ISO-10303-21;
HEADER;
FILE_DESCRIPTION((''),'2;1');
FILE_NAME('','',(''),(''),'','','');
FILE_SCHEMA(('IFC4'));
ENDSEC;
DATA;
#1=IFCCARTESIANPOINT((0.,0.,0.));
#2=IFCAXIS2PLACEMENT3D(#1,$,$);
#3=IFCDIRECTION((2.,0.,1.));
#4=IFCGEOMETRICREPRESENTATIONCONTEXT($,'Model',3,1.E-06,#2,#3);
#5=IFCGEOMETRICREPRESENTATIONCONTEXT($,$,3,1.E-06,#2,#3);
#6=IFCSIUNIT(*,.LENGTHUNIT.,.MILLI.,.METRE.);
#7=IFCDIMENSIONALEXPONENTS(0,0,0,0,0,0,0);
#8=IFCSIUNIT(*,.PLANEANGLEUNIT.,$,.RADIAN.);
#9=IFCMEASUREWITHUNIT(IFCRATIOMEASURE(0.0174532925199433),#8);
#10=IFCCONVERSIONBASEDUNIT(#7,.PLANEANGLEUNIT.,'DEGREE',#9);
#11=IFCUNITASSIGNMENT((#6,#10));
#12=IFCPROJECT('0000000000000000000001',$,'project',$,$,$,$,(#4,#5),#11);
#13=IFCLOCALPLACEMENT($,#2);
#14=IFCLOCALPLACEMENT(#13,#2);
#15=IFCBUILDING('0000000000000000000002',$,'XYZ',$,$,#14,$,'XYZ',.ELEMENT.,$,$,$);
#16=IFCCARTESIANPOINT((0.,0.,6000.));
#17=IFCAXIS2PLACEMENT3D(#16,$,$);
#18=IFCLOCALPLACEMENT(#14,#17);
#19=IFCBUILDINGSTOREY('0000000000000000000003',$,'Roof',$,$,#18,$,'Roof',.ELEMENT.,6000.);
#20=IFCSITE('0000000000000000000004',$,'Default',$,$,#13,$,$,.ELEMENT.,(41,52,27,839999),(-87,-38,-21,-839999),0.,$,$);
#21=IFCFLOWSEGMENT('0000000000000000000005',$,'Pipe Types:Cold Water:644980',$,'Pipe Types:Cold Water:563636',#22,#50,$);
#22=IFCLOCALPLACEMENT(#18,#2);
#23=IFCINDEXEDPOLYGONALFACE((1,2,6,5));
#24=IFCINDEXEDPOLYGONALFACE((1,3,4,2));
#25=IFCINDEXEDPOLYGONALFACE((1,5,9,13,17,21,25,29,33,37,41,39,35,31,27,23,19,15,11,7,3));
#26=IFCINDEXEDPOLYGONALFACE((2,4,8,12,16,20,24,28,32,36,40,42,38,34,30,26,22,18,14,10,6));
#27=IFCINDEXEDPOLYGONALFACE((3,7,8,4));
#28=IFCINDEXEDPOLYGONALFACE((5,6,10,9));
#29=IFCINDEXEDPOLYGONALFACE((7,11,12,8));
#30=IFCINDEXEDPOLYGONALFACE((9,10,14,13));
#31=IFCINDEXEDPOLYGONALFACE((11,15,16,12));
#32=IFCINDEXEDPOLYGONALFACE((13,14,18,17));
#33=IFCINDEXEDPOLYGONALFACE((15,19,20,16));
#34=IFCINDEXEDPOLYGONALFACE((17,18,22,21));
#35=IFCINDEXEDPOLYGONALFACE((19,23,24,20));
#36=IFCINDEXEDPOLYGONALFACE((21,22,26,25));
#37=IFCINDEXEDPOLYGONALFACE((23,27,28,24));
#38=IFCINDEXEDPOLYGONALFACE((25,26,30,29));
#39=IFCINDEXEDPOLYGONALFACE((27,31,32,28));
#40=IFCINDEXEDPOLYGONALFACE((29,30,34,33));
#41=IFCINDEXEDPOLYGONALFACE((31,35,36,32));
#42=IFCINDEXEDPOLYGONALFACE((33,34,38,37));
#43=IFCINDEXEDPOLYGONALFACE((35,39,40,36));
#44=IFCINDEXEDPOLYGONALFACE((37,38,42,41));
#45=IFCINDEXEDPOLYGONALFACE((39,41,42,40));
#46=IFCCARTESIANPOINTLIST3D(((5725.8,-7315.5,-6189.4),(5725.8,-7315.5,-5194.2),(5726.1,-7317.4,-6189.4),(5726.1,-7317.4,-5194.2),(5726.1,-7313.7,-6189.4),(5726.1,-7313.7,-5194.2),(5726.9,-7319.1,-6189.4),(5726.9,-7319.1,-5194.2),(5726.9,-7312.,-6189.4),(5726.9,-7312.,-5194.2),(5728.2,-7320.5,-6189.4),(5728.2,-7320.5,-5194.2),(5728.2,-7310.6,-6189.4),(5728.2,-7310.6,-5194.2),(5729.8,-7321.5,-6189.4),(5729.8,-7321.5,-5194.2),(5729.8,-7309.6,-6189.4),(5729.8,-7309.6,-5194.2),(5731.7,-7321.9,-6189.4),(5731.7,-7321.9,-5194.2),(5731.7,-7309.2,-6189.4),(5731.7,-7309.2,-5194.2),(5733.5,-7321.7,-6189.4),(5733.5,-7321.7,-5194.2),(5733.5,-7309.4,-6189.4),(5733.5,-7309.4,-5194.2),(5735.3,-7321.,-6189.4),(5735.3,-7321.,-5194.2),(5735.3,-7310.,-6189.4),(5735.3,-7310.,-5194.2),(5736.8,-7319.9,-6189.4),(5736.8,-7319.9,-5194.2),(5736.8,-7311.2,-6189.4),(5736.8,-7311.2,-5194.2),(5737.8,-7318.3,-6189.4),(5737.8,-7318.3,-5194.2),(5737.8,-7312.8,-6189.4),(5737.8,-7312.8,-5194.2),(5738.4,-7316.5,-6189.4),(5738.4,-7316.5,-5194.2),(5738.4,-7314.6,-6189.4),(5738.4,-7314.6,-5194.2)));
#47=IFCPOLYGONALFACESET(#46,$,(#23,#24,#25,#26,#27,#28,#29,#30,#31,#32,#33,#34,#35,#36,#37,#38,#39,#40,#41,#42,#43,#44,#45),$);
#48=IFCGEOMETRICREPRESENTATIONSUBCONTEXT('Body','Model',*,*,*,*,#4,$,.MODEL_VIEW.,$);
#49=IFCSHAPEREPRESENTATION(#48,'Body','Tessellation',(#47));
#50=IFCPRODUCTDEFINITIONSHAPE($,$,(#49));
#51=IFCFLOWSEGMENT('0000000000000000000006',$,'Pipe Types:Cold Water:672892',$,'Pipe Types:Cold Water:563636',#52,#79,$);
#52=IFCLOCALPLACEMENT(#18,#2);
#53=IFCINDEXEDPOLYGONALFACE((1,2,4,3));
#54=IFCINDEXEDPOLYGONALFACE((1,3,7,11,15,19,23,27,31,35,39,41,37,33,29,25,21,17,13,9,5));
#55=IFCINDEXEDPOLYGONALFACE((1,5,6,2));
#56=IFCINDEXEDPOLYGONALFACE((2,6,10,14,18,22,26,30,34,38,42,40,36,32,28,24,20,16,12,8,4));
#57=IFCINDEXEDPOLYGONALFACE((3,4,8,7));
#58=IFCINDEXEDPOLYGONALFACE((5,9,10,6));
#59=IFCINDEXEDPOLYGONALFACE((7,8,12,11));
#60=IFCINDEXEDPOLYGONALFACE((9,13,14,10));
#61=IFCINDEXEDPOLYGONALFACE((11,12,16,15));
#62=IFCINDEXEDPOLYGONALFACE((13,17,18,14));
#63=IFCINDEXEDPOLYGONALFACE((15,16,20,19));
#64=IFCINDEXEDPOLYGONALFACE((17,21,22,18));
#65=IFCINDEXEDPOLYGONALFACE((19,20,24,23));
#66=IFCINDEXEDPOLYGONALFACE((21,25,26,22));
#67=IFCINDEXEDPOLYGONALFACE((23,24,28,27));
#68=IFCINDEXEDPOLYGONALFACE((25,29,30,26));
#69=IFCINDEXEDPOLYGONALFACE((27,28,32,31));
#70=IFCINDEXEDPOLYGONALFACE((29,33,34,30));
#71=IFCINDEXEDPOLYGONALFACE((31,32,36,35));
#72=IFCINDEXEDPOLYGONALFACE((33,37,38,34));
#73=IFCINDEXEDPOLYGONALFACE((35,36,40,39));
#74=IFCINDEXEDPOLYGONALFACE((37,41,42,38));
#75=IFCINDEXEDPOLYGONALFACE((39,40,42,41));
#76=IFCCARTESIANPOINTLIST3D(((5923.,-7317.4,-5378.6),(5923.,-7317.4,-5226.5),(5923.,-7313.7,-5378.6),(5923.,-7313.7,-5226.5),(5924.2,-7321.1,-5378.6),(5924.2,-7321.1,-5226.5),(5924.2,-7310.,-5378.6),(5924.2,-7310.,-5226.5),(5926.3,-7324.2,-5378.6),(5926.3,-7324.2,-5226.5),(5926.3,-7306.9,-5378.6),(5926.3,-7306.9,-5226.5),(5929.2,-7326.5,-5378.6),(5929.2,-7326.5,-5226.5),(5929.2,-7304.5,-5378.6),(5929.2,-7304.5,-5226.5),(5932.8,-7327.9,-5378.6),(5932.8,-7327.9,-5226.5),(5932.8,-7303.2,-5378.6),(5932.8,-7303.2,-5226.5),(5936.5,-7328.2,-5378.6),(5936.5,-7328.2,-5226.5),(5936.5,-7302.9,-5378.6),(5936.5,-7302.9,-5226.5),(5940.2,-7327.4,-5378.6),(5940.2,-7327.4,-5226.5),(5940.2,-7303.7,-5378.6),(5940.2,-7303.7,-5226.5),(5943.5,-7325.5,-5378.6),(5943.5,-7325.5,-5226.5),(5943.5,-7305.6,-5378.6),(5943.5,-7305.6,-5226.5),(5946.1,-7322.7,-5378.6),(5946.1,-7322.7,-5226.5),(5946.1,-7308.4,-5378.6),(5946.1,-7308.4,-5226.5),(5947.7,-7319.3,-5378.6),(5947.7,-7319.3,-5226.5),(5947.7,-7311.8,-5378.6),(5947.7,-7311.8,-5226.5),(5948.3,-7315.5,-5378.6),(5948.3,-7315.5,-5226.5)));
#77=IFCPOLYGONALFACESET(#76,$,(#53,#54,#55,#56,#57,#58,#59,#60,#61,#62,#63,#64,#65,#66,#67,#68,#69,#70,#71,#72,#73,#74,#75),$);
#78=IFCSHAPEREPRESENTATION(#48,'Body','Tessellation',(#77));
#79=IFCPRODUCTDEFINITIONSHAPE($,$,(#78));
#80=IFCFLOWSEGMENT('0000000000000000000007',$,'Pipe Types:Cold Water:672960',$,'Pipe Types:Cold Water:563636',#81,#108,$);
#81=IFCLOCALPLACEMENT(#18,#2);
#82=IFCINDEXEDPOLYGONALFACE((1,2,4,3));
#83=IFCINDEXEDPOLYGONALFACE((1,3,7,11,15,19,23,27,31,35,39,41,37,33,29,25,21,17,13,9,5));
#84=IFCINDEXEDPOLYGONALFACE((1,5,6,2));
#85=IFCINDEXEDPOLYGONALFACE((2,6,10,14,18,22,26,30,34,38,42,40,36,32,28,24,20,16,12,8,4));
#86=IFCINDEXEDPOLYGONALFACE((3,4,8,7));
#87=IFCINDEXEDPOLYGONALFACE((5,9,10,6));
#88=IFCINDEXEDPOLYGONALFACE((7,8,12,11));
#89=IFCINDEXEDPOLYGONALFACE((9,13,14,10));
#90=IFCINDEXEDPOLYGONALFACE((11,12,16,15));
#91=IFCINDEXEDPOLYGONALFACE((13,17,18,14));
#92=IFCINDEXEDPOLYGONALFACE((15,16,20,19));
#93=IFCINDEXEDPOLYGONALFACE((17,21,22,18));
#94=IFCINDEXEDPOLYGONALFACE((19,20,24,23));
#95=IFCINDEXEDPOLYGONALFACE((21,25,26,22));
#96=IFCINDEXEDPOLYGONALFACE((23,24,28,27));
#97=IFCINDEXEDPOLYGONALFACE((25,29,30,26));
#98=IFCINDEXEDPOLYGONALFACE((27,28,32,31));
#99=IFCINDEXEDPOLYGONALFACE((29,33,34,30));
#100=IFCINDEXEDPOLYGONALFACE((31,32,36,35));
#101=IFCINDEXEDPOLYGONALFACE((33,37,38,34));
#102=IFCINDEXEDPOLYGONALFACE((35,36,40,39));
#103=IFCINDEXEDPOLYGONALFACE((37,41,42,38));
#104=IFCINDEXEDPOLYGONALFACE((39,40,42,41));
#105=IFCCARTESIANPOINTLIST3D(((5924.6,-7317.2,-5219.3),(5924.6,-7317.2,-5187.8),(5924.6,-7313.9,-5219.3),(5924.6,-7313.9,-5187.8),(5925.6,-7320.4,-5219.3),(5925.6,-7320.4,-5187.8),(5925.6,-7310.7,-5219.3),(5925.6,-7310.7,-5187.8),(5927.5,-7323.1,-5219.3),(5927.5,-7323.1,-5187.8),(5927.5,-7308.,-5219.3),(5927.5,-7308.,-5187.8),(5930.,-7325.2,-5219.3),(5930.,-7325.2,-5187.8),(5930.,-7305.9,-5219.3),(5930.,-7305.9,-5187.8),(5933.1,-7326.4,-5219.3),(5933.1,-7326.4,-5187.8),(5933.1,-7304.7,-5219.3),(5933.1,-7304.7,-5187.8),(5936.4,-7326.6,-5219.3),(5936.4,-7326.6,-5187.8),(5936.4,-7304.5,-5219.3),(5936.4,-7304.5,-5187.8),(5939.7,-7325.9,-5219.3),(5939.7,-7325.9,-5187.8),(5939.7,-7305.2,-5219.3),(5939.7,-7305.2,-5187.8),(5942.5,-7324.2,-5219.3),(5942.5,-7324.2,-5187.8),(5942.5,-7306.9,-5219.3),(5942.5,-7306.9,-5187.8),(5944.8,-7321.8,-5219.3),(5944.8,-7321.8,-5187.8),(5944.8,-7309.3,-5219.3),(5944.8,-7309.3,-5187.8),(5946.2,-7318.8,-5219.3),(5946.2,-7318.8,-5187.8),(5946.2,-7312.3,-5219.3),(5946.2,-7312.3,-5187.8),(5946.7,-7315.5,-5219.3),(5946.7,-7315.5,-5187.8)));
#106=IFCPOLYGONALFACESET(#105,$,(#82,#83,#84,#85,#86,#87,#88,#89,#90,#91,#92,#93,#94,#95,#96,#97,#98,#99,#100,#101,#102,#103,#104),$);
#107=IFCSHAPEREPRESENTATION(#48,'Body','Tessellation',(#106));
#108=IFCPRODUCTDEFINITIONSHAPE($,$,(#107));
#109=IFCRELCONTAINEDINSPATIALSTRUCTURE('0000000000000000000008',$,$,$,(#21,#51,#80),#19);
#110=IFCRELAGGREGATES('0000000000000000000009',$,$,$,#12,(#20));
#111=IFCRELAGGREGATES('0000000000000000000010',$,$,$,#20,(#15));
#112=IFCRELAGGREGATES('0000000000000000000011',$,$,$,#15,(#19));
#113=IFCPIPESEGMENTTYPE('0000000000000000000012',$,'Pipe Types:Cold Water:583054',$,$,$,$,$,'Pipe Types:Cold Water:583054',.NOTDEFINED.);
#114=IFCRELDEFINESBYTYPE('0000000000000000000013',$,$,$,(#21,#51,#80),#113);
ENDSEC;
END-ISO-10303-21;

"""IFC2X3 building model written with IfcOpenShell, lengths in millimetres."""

from ifc_helpers import new_model, entity, si_unit, converted_unit, direction, frame, frame_2d, origin, origin_2d_with_axis, place, context, subcontext, project, spatial, circle, extrude, type_object, element, save


model = new_model("IFC2X3")

# Units and contexts
model_context = context("Model", 3, precision=1e-06, world=origin(), true_north=direction((2.0, 0.0, 1.0)))
context_of_model = context(None, 3, precision=1e-06, world=origin(), true_north=direction((2.0, 0.0, 1.0)))
body_context = subcontext(model_context, "Body", "Model", "MODEL_VIEW")
ifc_project = project(units=[si_unit("LENGTHUNIT", "METRE", prefix="MILLI"), converted_unit("PLANEANGLEUNIT", "DEGREE", entity("IfcRatioMeasure", 0.0174532925199433), si_unit("PLANEANGLEUNIT", "RADIAN"), dimensions=[0, 0, 0, 0, 0, 0, 0])], contexts=[model_context, context_of_model])

# Site, building, storey
site_placement = place(None, origin())
site = spatial("IfcSite", under=ifc_project, at=site_placement, Name="Default", CompositionType="ELEMENT", RefLatitude=(41, 52, 27, 839999), RefLongitude=(-87, -38, -21, -839999), RefElevation=0.0)
building_placement = place(site_placement, origin())
building = spatial("IfcBuilding", under=site, at=building_placement, Name="XYZ", LongName="XYZ", CompositionType="ELEMENT")
storey_placement = place(building_placement, frame((0.0, 0.0, 6000.0)))
storey = spatial("IfcBuildingStorey", under=building, at=storey_placement, Name="Roof", LongName="Roof", CompositionType="ELEMENT", Elevation=6000.0)

# Flow segments
pipe_segment_type = type_object("IfcPipeSegmentType", Name="Pipe Types:Cold Water:583054", ElementType="Pipe Types:Cold Water:583054", PredefinedType="NOTDEFINED")
flow_segment_1_placement = place(storey_placement, origin())
element("IfcFlowSegment", 1, at=flow_segment_1_placement, inside=storey, type_object=pipe_segment_type, Name="Pipe Types:Cold Water:644980", ObjectType="Pipe Types:Cold Water:563636", context=body_context, shape_type="SweptSolid", body=[
    extrude(circle(Radius=6.3, at=origin_2d_with_axis()), frame((5732.1, -7315.5, -6189.4), z_axis=(0.0, 0.0, 1.0), x_axis=(-1.0, 0.0, 0.0)), (0.0, 0.0, 1.0), 995.2),
])
flow_segment_2_placement = place(storey_placement, origin())
element("IfcFlowSegment", 2, at=flow_segment_2_placement, inside=storey, type_object=pipe_segment_type, Name="Pipe Types:Cold Water:672892", ObjectType="Pipe Types:Cold Water:563636", context=body_context, shape_type="SweptSolid", body=[
    extrude(circle(Radius=12.7, at=origin_2d_with_axis()), frame((5935.6, -7315.5, -5378.6)), (0.0, 0.0, 1.0), 152.1),
])
flow_segment_3_placement = place(storey_placement, origin())
element("IfcFlowSegment", 3, at=flow_segment_3_placement, inside=storey, type_object=pipe_segment_type, Name="Pipe Types:Cold Water:672960", ObjectType="Pipe Types:Cold Water:563636", context=body_context, shape_type="SweptSolid", body=[
    extrude(circle(Radius=11.1, at=frame_2d((0.0, 0.0), x_axis=(1.0, 0.0))), frame((5935.6, -7315.5, -5219.3)), (0.0, 0.0, 1.0), 31.5),
])

save(model, "model.ifc")
